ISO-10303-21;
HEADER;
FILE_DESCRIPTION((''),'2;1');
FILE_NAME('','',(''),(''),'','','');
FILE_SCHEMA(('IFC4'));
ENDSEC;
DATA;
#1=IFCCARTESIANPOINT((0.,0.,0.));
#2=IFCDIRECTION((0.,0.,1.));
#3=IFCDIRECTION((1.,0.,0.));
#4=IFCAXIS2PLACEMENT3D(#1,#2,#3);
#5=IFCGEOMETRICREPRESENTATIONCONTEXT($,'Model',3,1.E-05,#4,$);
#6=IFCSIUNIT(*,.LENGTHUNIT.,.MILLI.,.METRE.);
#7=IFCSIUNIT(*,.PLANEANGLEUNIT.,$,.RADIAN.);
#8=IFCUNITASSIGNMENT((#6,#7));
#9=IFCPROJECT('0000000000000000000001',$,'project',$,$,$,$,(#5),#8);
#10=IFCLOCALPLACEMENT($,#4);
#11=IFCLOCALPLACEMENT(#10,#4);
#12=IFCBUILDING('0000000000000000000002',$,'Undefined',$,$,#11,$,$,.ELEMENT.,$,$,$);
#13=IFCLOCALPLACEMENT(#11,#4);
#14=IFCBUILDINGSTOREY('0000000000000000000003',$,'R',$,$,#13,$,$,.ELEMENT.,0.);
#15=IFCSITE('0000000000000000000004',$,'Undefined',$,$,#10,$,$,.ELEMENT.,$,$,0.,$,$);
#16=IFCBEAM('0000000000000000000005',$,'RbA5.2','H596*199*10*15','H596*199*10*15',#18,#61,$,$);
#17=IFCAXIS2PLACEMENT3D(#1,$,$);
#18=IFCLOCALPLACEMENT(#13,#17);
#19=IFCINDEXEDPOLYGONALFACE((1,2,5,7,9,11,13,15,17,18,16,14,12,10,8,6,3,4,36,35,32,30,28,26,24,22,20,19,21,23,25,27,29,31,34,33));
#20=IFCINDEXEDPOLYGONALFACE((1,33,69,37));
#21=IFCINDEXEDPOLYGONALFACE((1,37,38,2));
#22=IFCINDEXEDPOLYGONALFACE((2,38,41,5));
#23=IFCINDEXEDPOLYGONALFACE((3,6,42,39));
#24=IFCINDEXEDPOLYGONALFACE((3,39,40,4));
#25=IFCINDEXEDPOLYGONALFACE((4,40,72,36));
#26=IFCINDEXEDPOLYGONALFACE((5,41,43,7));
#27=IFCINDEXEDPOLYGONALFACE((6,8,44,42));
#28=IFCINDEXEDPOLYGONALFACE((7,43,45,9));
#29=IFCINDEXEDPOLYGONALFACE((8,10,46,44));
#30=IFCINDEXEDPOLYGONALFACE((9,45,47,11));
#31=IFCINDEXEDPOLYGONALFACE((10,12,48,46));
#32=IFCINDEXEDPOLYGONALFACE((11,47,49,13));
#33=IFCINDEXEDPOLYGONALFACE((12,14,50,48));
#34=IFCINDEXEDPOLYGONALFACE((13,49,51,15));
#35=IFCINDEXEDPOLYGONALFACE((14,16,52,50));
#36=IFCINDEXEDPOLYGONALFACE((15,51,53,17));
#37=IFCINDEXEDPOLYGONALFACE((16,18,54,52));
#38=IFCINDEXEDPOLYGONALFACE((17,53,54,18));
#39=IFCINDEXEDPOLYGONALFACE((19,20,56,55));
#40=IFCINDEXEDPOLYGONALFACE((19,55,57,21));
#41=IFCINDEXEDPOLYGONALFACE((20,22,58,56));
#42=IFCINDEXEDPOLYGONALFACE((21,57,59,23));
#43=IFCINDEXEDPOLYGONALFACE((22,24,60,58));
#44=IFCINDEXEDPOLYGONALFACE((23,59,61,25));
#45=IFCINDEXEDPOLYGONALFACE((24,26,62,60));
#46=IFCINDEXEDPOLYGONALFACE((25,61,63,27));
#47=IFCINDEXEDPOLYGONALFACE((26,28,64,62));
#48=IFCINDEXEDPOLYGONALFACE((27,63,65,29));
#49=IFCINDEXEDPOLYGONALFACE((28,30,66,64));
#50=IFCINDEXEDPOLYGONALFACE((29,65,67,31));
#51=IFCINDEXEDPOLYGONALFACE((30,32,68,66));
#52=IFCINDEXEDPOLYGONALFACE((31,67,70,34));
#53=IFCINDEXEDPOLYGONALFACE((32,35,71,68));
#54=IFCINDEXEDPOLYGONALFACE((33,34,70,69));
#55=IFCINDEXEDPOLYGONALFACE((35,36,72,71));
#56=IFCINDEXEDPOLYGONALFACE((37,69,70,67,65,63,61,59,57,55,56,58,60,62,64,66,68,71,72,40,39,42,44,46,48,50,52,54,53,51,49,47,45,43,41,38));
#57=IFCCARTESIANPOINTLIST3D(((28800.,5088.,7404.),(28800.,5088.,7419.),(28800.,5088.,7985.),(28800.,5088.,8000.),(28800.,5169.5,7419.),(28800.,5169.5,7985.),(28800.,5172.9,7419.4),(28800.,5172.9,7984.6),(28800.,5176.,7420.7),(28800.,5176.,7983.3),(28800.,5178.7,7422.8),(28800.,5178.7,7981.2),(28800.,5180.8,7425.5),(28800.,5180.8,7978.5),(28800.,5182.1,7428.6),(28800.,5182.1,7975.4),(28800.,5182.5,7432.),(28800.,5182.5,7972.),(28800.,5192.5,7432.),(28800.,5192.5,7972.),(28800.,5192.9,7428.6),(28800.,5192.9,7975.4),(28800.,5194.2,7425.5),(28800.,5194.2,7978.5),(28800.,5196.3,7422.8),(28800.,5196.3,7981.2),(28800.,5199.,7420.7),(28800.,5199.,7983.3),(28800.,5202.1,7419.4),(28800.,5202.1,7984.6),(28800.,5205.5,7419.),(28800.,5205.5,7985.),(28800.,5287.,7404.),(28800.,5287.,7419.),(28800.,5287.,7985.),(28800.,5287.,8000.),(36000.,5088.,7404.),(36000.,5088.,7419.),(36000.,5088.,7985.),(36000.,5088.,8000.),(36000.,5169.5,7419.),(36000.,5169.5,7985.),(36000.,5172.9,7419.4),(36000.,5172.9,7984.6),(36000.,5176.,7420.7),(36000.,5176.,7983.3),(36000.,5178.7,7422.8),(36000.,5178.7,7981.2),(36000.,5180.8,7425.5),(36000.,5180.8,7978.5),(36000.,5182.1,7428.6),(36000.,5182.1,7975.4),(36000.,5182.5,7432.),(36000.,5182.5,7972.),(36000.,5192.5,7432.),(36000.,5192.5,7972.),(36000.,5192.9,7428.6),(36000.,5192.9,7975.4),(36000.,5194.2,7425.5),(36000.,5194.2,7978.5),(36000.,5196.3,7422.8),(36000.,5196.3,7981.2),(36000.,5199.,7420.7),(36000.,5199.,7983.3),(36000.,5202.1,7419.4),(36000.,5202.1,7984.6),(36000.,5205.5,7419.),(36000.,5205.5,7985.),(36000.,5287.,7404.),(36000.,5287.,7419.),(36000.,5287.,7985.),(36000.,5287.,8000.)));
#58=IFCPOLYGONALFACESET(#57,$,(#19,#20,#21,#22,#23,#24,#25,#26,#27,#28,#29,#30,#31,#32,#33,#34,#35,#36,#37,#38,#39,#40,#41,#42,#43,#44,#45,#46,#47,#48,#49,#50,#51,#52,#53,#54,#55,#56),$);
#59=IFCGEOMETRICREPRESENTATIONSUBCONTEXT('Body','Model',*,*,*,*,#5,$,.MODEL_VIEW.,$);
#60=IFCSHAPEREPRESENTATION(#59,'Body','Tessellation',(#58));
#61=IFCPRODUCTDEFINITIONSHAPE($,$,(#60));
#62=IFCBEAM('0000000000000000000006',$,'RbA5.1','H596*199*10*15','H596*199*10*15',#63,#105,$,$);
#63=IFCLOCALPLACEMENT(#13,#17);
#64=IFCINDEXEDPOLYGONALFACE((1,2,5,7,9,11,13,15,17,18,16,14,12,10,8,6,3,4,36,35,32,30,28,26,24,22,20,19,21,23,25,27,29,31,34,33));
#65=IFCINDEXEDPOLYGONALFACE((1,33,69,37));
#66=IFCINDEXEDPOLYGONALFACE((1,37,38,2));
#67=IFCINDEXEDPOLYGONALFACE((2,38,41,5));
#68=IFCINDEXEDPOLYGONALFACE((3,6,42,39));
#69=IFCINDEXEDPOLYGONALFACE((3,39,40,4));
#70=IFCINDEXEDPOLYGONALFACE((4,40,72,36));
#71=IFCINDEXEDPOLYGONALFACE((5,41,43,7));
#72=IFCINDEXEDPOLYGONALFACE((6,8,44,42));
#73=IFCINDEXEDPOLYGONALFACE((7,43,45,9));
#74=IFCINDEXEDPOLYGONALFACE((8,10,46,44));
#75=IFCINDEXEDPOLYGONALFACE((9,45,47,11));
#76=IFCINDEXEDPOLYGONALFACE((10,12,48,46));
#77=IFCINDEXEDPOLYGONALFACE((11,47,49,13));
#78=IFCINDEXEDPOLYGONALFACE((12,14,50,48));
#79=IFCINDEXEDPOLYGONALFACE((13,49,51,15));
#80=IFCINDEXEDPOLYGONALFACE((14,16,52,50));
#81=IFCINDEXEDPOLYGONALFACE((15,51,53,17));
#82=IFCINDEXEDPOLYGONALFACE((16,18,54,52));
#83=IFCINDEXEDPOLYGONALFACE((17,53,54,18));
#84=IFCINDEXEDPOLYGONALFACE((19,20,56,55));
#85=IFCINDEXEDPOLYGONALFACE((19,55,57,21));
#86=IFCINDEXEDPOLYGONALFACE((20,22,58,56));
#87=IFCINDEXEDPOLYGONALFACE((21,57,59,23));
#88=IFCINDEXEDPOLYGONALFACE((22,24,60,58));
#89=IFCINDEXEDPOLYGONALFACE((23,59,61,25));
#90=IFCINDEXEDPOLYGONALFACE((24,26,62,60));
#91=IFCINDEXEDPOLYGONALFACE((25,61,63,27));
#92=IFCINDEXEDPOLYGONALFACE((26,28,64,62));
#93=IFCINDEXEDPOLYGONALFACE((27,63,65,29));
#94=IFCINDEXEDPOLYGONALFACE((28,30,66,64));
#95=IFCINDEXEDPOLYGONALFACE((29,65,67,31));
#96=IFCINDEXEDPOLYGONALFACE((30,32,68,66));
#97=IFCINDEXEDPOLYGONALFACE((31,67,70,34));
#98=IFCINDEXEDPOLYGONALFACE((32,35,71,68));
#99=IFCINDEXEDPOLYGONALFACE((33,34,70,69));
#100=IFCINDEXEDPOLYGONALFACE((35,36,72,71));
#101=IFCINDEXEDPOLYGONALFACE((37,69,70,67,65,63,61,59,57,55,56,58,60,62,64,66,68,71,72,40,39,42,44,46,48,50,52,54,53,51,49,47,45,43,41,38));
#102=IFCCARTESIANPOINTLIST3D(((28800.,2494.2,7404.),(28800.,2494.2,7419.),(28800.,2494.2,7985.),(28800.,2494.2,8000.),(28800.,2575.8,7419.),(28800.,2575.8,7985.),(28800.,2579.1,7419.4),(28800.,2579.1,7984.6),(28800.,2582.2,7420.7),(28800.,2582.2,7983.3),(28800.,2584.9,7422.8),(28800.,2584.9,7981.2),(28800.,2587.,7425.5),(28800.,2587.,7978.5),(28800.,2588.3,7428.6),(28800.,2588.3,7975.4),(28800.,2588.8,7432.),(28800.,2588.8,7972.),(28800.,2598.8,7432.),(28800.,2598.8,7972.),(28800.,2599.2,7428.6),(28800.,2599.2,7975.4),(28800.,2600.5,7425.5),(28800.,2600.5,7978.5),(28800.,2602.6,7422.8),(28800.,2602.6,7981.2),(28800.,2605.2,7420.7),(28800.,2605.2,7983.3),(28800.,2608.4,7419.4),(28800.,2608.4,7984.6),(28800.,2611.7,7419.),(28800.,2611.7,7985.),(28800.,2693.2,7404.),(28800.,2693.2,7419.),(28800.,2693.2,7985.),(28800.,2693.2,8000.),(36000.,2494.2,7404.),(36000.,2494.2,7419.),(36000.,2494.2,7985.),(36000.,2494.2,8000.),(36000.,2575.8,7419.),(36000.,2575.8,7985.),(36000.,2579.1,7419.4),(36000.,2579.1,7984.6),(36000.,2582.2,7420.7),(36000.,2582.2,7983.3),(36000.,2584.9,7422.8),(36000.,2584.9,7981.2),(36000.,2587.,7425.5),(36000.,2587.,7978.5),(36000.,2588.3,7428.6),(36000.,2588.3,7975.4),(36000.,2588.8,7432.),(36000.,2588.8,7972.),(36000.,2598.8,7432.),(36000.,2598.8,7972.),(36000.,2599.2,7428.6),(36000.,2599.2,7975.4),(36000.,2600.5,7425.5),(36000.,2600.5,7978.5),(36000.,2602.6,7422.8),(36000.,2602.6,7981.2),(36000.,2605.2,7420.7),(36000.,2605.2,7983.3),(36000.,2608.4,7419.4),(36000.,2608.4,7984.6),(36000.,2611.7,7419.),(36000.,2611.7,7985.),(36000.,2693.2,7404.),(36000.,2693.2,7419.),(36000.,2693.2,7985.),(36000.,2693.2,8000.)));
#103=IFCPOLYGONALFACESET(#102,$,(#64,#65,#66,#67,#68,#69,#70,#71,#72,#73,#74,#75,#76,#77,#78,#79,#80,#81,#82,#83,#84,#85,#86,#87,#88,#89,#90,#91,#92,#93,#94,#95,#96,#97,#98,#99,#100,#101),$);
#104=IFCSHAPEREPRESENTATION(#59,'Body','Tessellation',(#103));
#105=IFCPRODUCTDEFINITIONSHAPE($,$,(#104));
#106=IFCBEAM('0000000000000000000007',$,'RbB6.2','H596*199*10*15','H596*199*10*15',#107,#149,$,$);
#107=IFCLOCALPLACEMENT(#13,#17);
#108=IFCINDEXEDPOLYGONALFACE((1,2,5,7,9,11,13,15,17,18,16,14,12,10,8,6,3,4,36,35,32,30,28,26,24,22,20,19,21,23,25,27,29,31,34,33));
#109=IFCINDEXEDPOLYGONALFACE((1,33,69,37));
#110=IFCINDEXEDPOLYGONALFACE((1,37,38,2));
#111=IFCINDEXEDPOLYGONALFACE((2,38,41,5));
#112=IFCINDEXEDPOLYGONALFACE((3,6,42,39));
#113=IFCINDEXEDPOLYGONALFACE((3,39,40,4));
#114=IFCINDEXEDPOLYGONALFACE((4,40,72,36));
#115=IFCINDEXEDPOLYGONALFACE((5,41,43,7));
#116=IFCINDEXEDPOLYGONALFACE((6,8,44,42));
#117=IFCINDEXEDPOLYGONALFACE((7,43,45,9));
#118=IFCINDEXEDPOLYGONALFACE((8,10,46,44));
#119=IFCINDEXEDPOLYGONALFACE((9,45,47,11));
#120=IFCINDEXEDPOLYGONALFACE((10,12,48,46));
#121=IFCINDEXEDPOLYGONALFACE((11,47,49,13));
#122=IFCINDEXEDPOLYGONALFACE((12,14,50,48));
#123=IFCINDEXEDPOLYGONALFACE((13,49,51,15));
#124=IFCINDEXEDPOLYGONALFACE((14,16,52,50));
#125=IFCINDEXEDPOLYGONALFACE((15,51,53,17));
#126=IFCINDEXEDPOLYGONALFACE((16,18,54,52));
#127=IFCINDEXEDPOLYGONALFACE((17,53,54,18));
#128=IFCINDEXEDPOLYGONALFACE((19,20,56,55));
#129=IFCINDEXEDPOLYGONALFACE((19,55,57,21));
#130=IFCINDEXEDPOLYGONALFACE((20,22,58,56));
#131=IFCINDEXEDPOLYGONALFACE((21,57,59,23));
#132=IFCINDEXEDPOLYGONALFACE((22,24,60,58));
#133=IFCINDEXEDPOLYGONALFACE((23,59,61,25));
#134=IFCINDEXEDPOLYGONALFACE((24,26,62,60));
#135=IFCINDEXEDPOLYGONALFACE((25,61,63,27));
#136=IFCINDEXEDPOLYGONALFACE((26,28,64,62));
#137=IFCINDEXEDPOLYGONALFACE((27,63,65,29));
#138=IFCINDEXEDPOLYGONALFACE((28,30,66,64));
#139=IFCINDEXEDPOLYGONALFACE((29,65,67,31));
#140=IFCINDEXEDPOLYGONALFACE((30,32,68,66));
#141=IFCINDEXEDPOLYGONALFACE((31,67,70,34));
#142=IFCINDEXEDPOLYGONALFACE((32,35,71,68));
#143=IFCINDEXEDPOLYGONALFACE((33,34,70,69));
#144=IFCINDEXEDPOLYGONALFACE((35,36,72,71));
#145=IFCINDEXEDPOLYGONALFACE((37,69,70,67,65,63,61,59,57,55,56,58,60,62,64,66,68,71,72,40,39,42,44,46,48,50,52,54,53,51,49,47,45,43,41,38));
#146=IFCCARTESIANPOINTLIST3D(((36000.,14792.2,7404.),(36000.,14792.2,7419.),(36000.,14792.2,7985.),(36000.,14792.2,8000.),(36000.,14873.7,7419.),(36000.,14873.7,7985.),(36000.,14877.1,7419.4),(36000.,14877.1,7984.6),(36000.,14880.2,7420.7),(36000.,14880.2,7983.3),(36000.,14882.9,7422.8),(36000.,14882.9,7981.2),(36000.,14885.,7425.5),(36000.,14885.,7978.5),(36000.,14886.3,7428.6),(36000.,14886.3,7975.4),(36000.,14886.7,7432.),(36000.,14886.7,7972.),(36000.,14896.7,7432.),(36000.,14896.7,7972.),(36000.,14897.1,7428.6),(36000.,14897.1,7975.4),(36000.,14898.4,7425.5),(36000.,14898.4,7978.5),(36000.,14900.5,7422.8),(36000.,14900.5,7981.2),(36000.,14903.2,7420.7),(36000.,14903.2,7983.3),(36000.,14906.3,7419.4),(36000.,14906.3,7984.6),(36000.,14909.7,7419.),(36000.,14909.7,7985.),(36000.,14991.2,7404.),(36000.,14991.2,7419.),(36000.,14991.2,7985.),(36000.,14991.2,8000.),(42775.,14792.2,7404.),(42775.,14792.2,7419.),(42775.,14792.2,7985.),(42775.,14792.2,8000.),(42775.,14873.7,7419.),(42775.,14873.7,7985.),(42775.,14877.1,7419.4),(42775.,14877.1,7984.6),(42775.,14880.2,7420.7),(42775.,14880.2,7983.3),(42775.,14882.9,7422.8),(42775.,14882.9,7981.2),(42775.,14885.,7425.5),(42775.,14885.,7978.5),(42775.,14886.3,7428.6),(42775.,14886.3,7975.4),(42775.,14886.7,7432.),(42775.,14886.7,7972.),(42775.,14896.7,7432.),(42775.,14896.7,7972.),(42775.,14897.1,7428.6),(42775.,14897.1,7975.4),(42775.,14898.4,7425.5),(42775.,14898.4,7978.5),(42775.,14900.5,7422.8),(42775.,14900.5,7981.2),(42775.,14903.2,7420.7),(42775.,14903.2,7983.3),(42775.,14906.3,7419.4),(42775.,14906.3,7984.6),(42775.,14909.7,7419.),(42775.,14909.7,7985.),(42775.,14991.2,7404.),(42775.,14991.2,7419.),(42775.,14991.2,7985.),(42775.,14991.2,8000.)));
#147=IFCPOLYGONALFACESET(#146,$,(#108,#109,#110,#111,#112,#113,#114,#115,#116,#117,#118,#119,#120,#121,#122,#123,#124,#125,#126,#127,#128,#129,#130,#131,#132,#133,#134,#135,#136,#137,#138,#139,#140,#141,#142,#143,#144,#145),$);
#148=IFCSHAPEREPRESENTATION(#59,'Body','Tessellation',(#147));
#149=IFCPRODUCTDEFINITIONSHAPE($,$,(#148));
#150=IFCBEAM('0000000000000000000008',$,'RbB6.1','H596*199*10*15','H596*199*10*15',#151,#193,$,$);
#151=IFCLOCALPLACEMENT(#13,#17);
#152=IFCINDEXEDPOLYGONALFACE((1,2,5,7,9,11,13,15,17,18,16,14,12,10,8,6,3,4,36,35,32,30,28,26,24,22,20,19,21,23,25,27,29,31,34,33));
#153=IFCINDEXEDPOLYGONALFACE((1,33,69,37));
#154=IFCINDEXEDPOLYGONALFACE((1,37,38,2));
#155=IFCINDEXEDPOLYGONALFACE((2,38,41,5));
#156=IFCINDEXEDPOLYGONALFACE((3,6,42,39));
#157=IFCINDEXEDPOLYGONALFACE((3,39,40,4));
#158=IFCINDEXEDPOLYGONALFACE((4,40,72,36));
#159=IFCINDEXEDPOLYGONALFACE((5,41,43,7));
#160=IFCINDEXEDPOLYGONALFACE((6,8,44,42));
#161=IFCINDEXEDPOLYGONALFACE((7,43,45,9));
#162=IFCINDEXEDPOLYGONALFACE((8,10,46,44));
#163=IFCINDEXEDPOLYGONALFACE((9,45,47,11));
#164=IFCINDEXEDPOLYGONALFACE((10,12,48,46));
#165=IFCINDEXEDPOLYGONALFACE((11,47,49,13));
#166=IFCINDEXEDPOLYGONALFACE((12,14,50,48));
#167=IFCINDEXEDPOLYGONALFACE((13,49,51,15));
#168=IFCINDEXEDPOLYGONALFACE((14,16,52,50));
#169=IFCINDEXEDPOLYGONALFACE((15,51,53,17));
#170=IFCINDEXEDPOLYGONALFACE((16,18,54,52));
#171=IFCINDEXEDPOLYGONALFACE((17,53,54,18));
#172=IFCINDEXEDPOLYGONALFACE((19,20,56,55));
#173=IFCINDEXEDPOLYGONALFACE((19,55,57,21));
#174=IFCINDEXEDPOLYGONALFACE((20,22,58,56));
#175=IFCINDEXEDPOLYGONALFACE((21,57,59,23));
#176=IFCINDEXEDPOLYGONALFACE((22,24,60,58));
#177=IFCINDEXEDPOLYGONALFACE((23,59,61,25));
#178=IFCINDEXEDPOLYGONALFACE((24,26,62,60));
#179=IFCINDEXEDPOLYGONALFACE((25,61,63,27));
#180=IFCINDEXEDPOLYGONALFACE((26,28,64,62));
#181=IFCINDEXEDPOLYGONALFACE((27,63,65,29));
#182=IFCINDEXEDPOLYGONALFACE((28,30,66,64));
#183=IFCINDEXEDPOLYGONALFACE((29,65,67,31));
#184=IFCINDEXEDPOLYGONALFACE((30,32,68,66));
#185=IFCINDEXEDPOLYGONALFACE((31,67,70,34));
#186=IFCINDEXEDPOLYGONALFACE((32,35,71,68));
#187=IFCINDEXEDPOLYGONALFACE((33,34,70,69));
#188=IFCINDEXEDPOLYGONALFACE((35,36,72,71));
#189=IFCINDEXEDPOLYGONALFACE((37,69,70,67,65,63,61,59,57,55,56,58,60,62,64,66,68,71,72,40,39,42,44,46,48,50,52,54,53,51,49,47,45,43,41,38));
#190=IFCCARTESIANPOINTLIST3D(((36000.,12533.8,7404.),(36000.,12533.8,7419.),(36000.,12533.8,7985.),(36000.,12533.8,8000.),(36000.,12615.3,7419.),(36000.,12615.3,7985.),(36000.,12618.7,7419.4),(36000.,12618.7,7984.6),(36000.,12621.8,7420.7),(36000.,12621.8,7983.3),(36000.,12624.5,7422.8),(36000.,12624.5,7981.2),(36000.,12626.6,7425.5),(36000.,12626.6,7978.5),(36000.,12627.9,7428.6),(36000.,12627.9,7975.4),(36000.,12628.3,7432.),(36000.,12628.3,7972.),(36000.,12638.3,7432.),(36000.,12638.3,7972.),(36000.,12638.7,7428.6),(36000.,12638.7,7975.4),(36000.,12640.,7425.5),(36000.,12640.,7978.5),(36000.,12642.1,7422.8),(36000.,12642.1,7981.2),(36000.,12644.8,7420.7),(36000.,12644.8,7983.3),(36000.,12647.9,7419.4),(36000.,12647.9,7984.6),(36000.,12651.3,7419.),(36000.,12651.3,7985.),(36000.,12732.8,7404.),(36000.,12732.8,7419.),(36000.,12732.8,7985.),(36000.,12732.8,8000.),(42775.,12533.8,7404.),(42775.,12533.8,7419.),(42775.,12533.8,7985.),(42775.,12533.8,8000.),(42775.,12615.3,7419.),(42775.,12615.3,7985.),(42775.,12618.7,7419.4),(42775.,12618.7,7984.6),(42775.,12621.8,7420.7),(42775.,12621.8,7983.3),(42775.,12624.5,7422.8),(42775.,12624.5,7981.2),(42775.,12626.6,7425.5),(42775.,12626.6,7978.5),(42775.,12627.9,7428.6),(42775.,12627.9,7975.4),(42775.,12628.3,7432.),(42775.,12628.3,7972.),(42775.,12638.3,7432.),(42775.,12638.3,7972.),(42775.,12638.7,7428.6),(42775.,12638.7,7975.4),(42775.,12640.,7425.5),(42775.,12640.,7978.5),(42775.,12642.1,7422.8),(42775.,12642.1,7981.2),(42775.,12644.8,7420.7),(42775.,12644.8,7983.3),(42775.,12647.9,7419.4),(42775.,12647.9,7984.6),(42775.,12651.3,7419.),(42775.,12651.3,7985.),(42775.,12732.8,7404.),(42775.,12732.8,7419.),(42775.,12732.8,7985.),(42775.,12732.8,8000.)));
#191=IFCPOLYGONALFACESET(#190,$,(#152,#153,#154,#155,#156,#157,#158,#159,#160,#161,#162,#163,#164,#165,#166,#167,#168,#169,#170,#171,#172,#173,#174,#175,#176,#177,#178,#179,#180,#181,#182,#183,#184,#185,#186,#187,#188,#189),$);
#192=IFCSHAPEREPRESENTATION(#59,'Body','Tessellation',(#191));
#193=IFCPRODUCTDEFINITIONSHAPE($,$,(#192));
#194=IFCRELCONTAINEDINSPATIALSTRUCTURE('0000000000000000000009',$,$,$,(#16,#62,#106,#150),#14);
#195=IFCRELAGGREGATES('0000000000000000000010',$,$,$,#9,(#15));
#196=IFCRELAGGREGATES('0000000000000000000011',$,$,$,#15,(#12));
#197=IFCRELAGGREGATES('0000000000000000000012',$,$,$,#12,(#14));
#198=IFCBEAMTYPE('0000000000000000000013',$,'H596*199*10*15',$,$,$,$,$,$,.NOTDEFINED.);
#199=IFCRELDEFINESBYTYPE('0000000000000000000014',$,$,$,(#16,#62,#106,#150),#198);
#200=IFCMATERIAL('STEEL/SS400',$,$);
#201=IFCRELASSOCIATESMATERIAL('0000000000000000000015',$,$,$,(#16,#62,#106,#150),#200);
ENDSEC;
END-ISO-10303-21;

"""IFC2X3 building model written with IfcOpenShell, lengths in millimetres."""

from ifc_helpers import new_model, si_unit, frame, origin_with_axes, origin_2d_with_axis, place, context, subcontext, project, spatial, i_section, extrude, material, type_object, element, save


model = new_model("IFC2X3")

# Units and contexts
model_context = context("Model", 3, precision=1e-05, world=origin_with_axes())
body_context = subcontext(model_context, "Body", "Model", "MODEL_VIEW")
ifc_project = project(units=[si_unit("LENGTHUNIT", "METRE", prefix="MILLI"), si_unit("PLANEANGLEUNIT", "RADIAN")], contexts=[model_context])

# Site, building, storey
site_placement = place(None, origin_with_axes())
site = spatial("IfcSite", under=ifc_project, at=site_placement, Name="Undefined", CompositionType="ELEMENT", RefElevation=0.0)
building_placement = place(site_placement, origin_with_axes())
building = spatial("IfcBuilding", under=site, at=building_placement, Name="Undefined", CompositionType="ELEMENT")
storey_placement = place(building_placement, origin_with_axes())
storey = spatial("IfcBuildingStorey", under=building, at=storey_placement, Name="R", CompositionType="ELEMENT", Elevation=0.0)

# Beams
ifc_material_1 = material(Name="STEEL/SS400")
beam_type_1 = type_object("IfcBeamType", Name="H596*199*10*15", PredefinedType="NOTDEFINED")
for number, where, z_axis, x_axis, name in (
    (1, (28800.0, 5187.5, 7702.0), (0.0, 0.0, 1.0), (1.0, 0.0, 0.0), "RbA5.2"),
    (2, (28800.0, 2593.8, 7702.0), (0.0, 0.0, 1.0), (1.0, 0.0, 0.0), "RbA5.1"),
):
    element("IfcBeam", number, at=place(storey_placement, frame(where, z_axis=z_axis, x_axis=x_axis)), inside=storey, type_object=beam_type_1, material=ifc_material_1, Name=name, Description="H596*199*10*15", ObjectType="H596*199*10*15", context=body_context, shape_type="SweptSolid", body=[
        extrude(i_section(OverallWidth=199.0, OverallDepth=596.0, WebThickness=10.0, FlangeThickness=15.0, FilletRadius=13.0, at=origin_2d_with_axis()), frame((7200.0, 0.0, 0.0), z_axis=(-1.0, 0.0, 0.0), x_axis=(0.0, -1.0, 0.0)), (0.0, 0.0, 1.0), 7200.0),
    ])
for number, where, z_axis, x_axis, name in (
    (3, (36000.0, 14891.7, 7702.0), (0.0, 0.0, 1.0), (1.0, 0.0, 0.0), "RbB6.2"),
    (4, (36000.0, 12633.3, 7702.0), (0.0, 0.0, 1.0), (1.0, 0.0, 0.0), "RbB6.1"),
):
    element("IfcBeam", number, at=place(storey_placement, frame(where, z_axis=z_axis, x_axis=x_axis)), inside=storey, type_object=beam_type_1, material=ifc_material_1, Name=name, Description="H596*199*10*15", ObjectType="H596*199*10*15", context=body_context, shape_type="SweptSolid", body=[
        extrude(i_section(OverallWidth=199.0, OverallDepth=596.0, WebThickness=10.0, FlangeThickness=15.0, FilletRadius=13.0, at=origin_2d_with_axis()), frame((6775.0, 0.0, 0.0), z_axis=(-1.0, 0.0, 0.0), x_axis=(0.0, -1.0, 0.0)), (0.0, 0.0, 1.0), 6775.0),
    ])

save(model, "model.ifc")
